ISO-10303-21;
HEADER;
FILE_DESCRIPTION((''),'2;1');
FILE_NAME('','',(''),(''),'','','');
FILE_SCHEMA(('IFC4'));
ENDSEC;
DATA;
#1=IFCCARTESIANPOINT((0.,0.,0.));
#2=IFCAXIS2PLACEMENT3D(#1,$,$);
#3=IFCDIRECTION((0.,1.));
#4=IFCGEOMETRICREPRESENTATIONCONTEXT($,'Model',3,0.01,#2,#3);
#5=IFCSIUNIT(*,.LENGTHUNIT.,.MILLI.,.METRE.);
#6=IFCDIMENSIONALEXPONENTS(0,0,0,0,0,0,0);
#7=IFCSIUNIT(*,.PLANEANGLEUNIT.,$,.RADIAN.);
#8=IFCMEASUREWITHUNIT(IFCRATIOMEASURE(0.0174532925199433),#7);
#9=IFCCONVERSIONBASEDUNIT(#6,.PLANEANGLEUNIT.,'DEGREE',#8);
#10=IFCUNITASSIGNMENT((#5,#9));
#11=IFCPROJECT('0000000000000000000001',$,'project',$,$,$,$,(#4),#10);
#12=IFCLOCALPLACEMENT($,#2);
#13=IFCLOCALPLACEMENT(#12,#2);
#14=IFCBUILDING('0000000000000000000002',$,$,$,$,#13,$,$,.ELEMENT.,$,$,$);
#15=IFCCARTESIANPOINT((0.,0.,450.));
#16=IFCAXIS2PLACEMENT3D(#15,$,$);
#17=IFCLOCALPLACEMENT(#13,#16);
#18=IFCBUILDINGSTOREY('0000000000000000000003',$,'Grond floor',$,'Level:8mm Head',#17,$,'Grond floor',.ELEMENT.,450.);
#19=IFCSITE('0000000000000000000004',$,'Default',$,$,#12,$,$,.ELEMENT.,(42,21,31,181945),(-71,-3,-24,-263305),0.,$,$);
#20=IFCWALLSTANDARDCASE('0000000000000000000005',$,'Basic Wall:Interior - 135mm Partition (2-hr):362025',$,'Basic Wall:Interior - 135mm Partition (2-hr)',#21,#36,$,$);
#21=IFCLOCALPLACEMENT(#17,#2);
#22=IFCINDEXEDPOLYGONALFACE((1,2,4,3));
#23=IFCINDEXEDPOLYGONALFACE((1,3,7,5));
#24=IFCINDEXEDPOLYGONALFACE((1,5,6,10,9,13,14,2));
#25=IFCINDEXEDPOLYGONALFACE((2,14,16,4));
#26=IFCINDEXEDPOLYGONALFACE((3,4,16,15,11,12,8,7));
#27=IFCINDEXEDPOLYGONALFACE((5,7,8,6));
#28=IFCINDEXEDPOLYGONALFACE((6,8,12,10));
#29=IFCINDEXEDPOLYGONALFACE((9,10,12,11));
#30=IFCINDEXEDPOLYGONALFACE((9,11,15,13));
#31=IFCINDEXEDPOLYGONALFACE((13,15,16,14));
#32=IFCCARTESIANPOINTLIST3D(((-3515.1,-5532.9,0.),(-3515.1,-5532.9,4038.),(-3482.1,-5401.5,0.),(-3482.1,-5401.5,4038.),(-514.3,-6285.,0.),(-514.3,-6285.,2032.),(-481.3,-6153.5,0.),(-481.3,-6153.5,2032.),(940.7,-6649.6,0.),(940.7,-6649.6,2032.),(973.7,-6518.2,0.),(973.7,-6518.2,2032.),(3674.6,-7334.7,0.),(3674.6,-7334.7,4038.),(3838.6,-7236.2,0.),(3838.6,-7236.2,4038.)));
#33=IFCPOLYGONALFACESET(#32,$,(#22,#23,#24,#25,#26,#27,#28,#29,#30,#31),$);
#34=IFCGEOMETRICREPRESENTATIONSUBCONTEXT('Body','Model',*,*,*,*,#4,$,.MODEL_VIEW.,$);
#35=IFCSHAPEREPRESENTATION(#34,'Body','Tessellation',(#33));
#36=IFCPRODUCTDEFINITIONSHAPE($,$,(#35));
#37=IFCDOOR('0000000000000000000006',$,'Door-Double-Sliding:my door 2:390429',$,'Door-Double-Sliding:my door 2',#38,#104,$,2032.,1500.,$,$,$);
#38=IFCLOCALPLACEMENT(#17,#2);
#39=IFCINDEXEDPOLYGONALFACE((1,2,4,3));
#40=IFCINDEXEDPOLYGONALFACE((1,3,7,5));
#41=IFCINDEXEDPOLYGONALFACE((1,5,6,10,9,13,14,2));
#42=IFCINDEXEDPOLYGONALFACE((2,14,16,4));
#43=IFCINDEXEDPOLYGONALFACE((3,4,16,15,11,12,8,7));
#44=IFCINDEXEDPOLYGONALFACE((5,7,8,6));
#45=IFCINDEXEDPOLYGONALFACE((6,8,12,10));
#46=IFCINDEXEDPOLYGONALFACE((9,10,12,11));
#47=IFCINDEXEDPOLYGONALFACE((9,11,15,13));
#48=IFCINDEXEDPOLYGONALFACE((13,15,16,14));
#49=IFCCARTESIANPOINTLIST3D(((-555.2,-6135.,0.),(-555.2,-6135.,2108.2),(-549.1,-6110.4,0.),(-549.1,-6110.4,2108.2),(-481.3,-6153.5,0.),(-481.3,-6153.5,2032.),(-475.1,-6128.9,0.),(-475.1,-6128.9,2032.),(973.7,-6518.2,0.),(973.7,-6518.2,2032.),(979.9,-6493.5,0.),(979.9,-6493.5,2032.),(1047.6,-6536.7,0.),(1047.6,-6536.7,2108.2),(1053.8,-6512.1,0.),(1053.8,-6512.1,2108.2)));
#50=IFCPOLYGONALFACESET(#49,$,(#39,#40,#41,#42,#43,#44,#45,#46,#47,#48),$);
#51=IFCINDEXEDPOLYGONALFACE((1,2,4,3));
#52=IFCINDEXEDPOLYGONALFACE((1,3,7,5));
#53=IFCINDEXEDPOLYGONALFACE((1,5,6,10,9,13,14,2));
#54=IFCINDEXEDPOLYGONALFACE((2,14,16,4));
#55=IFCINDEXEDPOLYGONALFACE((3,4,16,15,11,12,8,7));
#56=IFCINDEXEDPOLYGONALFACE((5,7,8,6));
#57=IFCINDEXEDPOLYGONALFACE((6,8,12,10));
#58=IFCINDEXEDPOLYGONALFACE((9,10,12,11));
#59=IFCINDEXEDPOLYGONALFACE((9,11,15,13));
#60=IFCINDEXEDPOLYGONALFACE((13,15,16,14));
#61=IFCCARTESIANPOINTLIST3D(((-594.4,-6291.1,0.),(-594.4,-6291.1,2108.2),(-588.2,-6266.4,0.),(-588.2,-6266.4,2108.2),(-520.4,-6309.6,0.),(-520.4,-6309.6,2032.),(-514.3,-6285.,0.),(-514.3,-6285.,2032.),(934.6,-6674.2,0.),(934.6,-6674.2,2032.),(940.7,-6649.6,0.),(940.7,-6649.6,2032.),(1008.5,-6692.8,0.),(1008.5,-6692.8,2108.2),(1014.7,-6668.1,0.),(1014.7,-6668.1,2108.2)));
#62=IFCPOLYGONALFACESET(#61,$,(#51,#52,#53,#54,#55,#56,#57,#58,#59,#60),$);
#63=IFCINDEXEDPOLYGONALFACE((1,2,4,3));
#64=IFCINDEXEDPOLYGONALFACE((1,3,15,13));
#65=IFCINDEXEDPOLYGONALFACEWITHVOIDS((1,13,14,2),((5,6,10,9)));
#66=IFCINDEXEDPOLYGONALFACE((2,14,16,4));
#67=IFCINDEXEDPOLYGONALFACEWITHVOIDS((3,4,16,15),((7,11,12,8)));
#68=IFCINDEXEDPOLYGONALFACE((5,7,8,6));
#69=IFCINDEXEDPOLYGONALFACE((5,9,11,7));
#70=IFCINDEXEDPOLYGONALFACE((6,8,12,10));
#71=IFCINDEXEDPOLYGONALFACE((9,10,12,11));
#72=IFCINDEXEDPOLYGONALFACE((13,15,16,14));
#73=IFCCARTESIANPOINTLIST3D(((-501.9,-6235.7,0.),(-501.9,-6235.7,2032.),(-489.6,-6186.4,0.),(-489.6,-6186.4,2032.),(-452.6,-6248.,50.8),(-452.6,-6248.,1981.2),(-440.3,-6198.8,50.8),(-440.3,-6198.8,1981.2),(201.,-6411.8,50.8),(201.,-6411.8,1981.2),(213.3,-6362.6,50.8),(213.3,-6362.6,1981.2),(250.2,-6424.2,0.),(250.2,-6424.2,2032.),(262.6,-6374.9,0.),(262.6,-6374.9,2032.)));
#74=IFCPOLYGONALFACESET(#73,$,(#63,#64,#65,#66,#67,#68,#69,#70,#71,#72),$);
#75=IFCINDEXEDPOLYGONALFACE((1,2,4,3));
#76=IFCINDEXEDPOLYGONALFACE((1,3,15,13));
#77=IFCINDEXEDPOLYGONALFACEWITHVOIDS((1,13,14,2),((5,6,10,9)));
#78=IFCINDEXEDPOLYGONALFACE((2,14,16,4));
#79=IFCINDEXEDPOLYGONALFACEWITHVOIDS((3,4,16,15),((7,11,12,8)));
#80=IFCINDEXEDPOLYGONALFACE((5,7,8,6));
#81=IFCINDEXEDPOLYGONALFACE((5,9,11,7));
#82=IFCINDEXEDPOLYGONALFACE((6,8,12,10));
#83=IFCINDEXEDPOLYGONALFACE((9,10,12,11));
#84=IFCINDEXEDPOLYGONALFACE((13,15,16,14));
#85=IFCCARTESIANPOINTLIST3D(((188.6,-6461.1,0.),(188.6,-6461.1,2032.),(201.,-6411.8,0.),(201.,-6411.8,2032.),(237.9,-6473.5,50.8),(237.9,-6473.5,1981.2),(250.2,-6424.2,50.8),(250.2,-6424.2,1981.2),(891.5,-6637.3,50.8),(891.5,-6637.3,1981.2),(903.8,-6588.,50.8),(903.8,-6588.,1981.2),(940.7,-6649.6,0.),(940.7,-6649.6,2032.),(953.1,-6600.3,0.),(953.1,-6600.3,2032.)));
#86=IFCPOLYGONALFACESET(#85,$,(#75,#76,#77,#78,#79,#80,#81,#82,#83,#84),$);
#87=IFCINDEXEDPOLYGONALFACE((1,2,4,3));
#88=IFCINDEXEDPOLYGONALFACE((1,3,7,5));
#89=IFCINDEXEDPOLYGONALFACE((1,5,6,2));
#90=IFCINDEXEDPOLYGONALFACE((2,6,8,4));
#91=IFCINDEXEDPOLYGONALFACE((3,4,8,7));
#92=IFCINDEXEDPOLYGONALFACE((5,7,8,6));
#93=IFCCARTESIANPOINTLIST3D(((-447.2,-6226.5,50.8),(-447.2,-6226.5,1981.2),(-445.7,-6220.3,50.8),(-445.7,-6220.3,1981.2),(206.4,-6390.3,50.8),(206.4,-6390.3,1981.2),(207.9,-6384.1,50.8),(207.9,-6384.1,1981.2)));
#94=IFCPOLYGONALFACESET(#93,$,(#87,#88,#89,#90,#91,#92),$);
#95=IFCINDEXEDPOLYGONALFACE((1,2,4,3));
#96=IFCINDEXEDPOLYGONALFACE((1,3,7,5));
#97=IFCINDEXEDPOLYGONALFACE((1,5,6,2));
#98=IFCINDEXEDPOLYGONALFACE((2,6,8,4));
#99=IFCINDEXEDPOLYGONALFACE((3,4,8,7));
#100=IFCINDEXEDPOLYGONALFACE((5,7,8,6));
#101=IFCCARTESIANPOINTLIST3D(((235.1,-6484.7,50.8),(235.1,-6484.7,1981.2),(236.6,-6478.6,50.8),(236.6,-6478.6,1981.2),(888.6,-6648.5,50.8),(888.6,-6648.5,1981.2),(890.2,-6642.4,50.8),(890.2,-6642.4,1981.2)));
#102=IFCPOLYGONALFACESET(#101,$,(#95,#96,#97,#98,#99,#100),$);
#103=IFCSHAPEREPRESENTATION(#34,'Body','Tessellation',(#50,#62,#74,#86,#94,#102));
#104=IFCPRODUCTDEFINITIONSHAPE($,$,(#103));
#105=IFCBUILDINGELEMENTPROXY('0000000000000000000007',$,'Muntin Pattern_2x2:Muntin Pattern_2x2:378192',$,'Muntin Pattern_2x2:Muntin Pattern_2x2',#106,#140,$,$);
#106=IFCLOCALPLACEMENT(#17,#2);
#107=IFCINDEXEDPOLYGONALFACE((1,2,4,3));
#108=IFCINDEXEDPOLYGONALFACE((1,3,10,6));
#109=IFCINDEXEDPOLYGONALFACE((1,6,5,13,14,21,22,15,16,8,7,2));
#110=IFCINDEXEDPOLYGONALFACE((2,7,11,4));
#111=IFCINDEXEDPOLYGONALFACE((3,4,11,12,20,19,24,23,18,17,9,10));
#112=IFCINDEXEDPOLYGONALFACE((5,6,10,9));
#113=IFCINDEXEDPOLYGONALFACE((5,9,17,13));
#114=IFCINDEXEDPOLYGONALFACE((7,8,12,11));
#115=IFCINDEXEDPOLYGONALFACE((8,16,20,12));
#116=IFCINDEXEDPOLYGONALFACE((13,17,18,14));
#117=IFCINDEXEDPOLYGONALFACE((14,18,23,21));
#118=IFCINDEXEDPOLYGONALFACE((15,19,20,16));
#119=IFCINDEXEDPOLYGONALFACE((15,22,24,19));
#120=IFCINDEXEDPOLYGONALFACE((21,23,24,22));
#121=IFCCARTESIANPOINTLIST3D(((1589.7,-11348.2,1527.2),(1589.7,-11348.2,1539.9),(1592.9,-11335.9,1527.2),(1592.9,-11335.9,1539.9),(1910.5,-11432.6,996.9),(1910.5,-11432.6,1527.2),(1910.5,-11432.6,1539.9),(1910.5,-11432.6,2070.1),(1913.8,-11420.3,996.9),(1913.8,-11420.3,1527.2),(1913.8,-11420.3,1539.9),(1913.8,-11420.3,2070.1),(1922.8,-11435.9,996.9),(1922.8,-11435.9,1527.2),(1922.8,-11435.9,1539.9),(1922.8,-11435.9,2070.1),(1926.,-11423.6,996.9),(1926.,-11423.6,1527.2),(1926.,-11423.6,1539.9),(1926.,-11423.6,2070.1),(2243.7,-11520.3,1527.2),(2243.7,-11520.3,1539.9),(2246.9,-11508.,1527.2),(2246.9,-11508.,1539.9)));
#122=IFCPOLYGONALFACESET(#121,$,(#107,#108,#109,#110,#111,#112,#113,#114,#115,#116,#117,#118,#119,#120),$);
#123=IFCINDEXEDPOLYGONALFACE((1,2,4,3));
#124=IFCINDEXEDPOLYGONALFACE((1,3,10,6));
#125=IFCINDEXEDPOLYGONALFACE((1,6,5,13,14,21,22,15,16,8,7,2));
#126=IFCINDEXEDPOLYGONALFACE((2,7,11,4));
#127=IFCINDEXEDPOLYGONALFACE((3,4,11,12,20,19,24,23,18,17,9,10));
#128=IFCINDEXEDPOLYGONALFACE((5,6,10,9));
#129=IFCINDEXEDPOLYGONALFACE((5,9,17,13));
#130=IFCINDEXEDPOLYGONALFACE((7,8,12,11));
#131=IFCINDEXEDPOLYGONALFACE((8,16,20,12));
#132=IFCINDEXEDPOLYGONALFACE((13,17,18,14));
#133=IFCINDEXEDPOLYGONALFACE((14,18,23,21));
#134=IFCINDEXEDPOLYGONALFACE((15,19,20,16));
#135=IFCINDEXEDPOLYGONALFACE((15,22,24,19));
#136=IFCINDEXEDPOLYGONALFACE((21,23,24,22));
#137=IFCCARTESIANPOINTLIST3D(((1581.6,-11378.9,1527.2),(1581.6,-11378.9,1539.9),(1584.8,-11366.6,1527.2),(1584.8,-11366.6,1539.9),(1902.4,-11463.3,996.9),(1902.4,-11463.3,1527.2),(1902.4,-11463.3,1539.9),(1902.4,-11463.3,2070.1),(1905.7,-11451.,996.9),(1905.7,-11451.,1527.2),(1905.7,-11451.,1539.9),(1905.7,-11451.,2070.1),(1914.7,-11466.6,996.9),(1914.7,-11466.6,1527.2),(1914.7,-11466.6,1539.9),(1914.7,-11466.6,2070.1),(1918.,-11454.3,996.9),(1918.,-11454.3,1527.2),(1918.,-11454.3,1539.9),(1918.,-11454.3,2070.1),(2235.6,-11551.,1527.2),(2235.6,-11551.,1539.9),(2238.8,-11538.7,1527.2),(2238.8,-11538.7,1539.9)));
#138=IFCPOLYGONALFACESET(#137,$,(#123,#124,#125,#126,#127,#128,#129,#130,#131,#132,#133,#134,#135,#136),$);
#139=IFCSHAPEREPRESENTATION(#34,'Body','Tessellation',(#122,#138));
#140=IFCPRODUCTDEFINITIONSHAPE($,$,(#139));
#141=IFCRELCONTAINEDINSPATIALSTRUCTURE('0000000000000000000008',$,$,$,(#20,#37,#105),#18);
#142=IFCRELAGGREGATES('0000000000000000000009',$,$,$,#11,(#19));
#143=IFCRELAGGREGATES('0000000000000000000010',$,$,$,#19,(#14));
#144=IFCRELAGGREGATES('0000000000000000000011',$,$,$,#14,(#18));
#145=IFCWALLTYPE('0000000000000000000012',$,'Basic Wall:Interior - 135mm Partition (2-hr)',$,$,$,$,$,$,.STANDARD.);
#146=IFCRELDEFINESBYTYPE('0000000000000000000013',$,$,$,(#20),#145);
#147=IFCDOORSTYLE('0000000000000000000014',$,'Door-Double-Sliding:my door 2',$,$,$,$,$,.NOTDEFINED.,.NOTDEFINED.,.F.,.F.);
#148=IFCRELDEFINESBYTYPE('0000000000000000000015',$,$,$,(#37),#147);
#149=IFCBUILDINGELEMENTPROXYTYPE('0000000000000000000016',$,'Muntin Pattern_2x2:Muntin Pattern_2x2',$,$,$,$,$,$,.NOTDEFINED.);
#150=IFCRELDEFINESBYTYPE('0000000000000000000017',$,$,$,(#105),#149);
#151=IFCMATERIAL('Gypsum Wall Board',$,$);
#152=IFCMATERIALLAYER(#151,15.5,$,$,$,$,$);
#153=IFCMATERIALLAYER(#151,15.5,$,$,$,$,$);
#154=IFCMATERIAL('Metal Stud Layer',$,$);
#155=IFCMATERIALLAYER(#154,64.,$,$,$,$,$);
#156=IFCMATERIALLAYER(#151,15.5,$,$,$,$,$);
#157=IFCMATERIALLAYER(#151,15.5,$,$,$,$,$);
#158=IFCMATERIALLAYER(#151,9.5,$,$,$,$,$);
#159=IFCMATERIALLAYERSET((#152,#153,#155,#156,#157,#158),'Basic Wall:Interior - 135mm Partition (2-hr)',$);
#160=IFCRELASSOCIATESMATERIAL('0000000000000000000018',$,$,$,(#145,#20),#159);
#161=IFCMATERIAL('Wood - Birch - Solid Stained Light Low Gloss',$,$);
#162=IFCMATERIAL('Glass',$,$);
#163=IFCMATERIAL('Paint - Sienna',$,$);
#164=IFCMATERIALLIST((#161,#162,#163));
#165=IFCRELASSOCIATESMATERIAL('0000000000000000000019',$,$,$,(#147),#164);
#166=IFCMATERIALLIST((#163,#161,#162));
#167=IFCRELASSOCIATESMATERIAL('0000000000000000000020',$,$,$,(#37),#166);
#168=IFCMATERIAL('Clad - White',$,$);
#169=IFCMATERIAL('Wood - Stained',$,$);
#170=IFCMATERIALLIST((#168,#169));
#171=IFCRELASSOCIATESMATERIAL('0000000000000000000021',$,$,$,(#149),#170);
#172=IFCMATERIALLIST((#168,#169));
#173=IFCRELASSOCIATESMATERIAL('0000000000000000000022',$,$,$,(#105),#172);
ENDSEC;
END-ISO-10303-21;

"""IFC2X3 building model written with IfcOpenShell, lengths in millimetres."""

from ifc_helpers import new_model, entity, si_unit, converted_unit, direction, frame, frame_2d, origin, origin_2d_with_axis, place, context, subcontext, project, spatial, polyline, rectangle, outline, extrude, source, transform, mapped, material, material_list, layer, layer_set, layer_usage, type_object, type_shapes, element, fill, save


model = new_model("IFC2X3")

# Units and contexts
model_context = context("Model", 3, precision=0.01, world=origin(), true_north=direction((0.0, 1.0)))
body_context = subcontext(model_context, "Body", "Model", "MODEL_VIEW")
ifc_project = project(units=[si_unit("LENGTHUNIT", "METRE", prefix="MILLI"), converted_unit("PLANEANGLEUNIT", "DEGREE", entity("IfcRatioMeasure", 0.0174532925199433), si_unit("PLANEANGLEUNIT", "RADIAN"), dimensions=[0, 0, 0, 0, 0, 0, 0])], contexts=[model_context])

# Site, building, storey
site_placement = place(None, origin())
site = spatial("IfcSite", under=ifc_project, at=site_placement, Name="Default", CompositionType="ELEMENT", RefLatitude=(42, 21, 31, 181945), RefLongitude=(-71, -3, -24, -263305), RefElevation=0.0)
building_placement = place(site_placement, origin())
building = spatial("IfcBuilding", under=site, at=building_placement, CompositionType="ELEMENT")
storey_placement = place(building_placement, frame((0.0, 0.0, 450.0)))
storey = spatial("IfcBuildingStorey", under=building, at=storey_placement, Name="Grond floor", ObjectType="Level:8mm Head", LongName="Grond floor", CompositionType="ELEMENT", Elevation=450.0)

# Shared definitions
ifc_material_1 = material(Name="Glass")

# Shared definitions
ifc_material_2 = material(Name="Gypsum Wall Board")

# Wall, openings, door
ifc_layer_1 = layer(ifc_material_2, 15.5)
ifc_layer_2 = layer(ifc_material_2, 15.5)
ifc_material_3 = material(Name="Metal Stud Layer")
ifc_layer_3 = layer(ifc_material_3, 64.0)
ifc_layer_4 = layer(ifc_material_2, 15.5)
ifc_layer_5 = layer(ifc_material_2, 15.5)
ifc_layer_6 = layer(ifc_material_2, 9.5)
ifc_layer_set_1 = layer_set([ifc_layer_1, ifc_layer_2, ifc_layer_3, ifc_layer_4, ifc_layer_5, ifc_layer_6], Name="Basic Wall:Interior - 135mm Partition (2-hr)")
ifc_layer_usage_1 = layer_usage(ifc_layer_set_1, "AXIS2", "NEGATIVE", 67.8)
wall_type_1 = type_object("IfcWallType", Name="Basic Wall:Interior - 135mm Partition (2-hr)", PredefinedType="STANDARD", material=ifc_layer_set_1)
wall_1_placement = place(storey_placement, frame((3822.2, -7301.9, 0.0), z_axis=(0.0, 0.0, 1.0), x_axis=(-0.970003, 0.243092, 0.0)))
wall_1 = element("IfcWallStandardCase", 1, at=wall_1_placement, inside=storey, type_object=wall_type_1, material=ifc_layer_usage_1, Name="Basic Wall:Interior - 135mm Partition (2-hr):362025", ObjectType="Basic Wall:Interior - 135mm Partition (2-hr)", context=body_context, shape_type="SweptSolid", body=[
    extrude(outline(polyline([(0.0, -67.8), (7547.1, -67.8), (7547.1, 67.7), (135.2, 67.7), (17.7, -50.0), (0.0, -67.8)])), origin(), (0.0, 0.0, 1.0), 4038.0),
])
opening_1_placement = place(wall_1_placement, origin())
element("IfcOpeningElement", 2, at=opening_1_placement, cuts=wall_1, ObjectType="Opening", context=body_context, shape_type="SweptSolid", body=[
    extrude(rectangle(XDim=2134.0, YDim=135.5, at=frame_2d((0.0, 0.0), x_axis=(0.0, 1.0))), frame((4614.9, 174.8, 1067.0), z_axis=(0.0, 1.0, 0.0), x_axis=(1.0, 0.0, 0.0)), (0.0, 0.0, 1.0), 813.0),
])
opening_2_placement = place(wall_1_placement, origin())
element("IfcOpeningElement", 3, at=opening_2_placement, cuts=wall_1, ObjectType="Opening", context=body_context, shape_type="SweptSolid", body=[
    extrude(rectangle(XDim=2134.0, YDim=135.5, at=frame_2d((0.0, 0.0), x_axis=(0.0, 1.0))), frame((2773.7, 196.6, 1067.0), z_axis=(0.0, 1.0, 0.0), x_axis=(1.0, 0.0, 0.0)), (0.0, 0.0, 1.0), 813.0),
])
opening_3_placement = place(wall_1_placement, origin())
element("IfcOpeningElement", 4, at=opening_3_placement, cuts=wall_1, ObjectType="Opening", context=body_context, shape_type="SweptSolid", body=[
    extrude(rectangle(XDim=2134.0, YDim=915.0, at=frame_2d((0.0, 0.0), x_axis=(0.0, 1.0))), frame((7996.1, -510.0, 1067.0), z_axis=(0.514003, 0.857788, 0.0), x_axis=(-0.857788, 0.514003, 0.0)), (0.0, 0.0, 1.0), 264.0),
])
opening_4_placement = place(wall_1_placement, frame((2953.5, -67.7, 0.0)))
opening_4 = element("IfcOpeningElement", 5, at=opening_4_placement, cuts=wall_1, ObjectType="Opening", context=body_context, shape_type="SweptSolid", body=[
    extrude(rectangle(XDim=2032.0, YDim=1500.0, at=frame_2d((1016.0, 750.0), x_axis=(-1.0, 0.0))), frame((0.0, 0.0, 0.0), z_axis=(0.0, 1.0, 0.0), x_axis=(0.0, 0.0, 1.0)), (0.0, 0.0, 1.0), 135.5),
])
ifc_material_4 = material(Name="Paint - Sienna")
ifc_material_5 = material(Name="Wood - Birch - Solid Stained Light Low Gloss")
ifc_material_list_1 = material_list([ifc_material_4, ifc_material_5, ifc_material_1])
ifc_material_list_2 = material_list([ifc_material_5, ifc_material_1, ifc_material_4])
door_style = type_object("IfcDoorStyle", Name="Door-Double-Sliding:my door 2", ConstructionType="NOTDEFINED", OperationType="NOTDEFINED", ParameterTakesPrecedence=False, Sizeable=False, material=ifc_material_list_2)
shared_shape_1 = source(origin(), body_context, "Body", "SweptSolid", [
    extrude(outline(polyline([(-1035.0, -826.2), (1073.2, -826.2), (1073.2, 826.2), (-1035.0, 826.2), (-1035.0, 750.0), (996.9, 750.0), (996.9, -750.0), (-1035.0, -750.0), (-1035.0, -826.2)])), frame((750.0, -25.4, 1035.0), z_axis=(0.0, 1.0, 0.0), x_axis=(0.0, 0.0, 1.0)), (0.0, 0.0, 1.0), 25.4),
    extrude(outline(polyline([(-826.2, -1035.0), (-750.0, -1035.0), (-750.0, 997.0), (750.0, 997.0), (750.0, -1035.0), (826.2, -1035.0), (826.2, 1073.2), (-826.2, 1073.2), (-826.2, -1035.0)])), frame((750.0, 135.5, 1035.0), z_axis=(0.0, 1.0, 0.0), x_axis=(-1.0, 0.0, 0.0)), (0.0, 0.0, 1.0), 25.4),
    extrude(outline(polyline([(-387.7, -1016.0), (387.7, -1016.0), (387.7, 1016.0), (-387.7, 1016.0), (-387.7, -1016.0)]), holes=[polyline([(-336.9, -965.2), (-336.9, 965.2), (336.9, 965.2), (336.9, -965.2), (-336.9, -965.2)])]), frame((1112.3, 33.9, 1016.0), z_axis=(0.0, 1.0, 0.0), x_axis=(1.0, 0.0, 0.0)), (0.0, 0.0, 1.0), 50.8),
    extrude(outline(polyline([(-1016.0, -387.7), (1016.0, -387.7), (1016.0, 387.7), (-1016.0, 387.7), (-1016.0, -387.7)]), holes=[polyline([(-965.2, -336.9), (-965.2, 336.9), (965.2, 336.9), (965.2, -336.9), (-965.2, -336.9)])]), frame((387.7, 84.7, 1016.0), z_axis=(0.0, 1.0, 0.0), x_axis=(0.0, 0.0, -1.0)), (0.0, 0.0, 1.0), 50.8),
    extrude(rectangle(XDim=6.3, YDim=673.8, at=frame_2d((0.0, 0.0), x_axis=(1.0, 0.0))), frame((1112.3, 59.3, 50.8), z_axis=(0.0, 0.0, 1.0), x_axis=(0.0, -1.0, 0.0)), (0.0, 0.0, 1.0), 1930.4),
    extrude(rectangle(XDim=6.4, YDim=673.8, at=origin_2d_with_axis()), frame((387.7, 144.0, 50.8), z_axis=(0.0, 0.0, 1.0), x_axis=(0.0, 1.0, 0.0)), (0.0, 0.0, 1.0), 1930.4),
])
type_shapes(door_style, [shared_shape_1])
door_placement = place(opening_4_placement, origin())
door = element("IfcDoor", 6, at=door_placement, inside=storey, type_object=door_style, material=ifc_material_list_1, Name="Door-Double-Sliding:my door 2:390429", ObjectType="Door-Double-Sliding:my door 2", OverallHeight=2032.0, OverallWidth=1500.0, context=body_context, shape_type="MappedRepresentation", body=[
    mapped(shared_shape_1, transform((0.0, 0.0, 0.0), scale=1.0)),
])
fill(opening_4, door)

# Building element proxy
ifc_material_6 = material(Name="Clad - White")
ifc_material_7 = material(Name="Wood - Stained")
ifc_material_list_3 = material_list([ifc_material_6, ifc_material_7])
ifc_material_list_4 = material_list([ifc_material_6, ifc_material_7])
building_element_proxy_type_1 = type_object("IfcBuildingElementProxyType", Name="Muntin Pattern_2x2:Muntin Pattern_2x2", PredefinedType="NOTDEFINED", material=ifc_material_list_4)
shared_shape_2 = source(origin(), body_context, "Body", "SweptSolid", [
    extrude(outline(polyline([(6.4, -6.4), (536.6, -6.4), (536.6, 6.3), (6.4, 6.3), (6.4, 338.1), (-6.3, 338.1), (-6.3, 6.3), (-536.6, 6.3), (-536.6, -6.4), (-6.3, -6.4), (-6.3, -338.1), (6.4, -338.1), (6.4, -6.4)])), frame((0.0, 9.5, 536.6), z_axis=(0.0, 1.0, 0.0), x_axis=(0.0, 0.0, 1.0)), (0.0, 0.0, 1.0), 12.7),
    extrude(outline(polyline([(6.4, -6.4), (536.6, -6.4), (536.6, 6.3), (6.4, 6.3), (6.4, 338.1), (-6.3, 338.1), (-6.3, 6.3), (-536.6, 6.3), (-536.6, -6.4), (-6.3, -6.4), (-6.3, -338.1), (6.4, -338.1), (6.4, -6.4)])), frame((0.0, -22.2, 536.6), z_axis=(0.0, 1.0, 0.0), x_axis=(0.0, 0.0, 1.0)), (0.0, 0.0, 1.0), 12.7),
])
type_shapes(building_element_proxy_type_1, [shared_shape_2])
proxy_1_placement = place(storey_placement, frame((1914.2, -11443.4, 996.9), z_axis=(0.0, 0.0, 1.0), x_axis=(0.967067, -0.25452, 0.0)))
element("IfcBuildingElementProxy", 7, at=proxy_1_placement, inside=storey, type_object=building_element_proxy_type_1, material=ifc_material_list_3, Name="Muntin Pattern_2x2:Muntin Pattern_2x2:378192", ObjectType="Muntin Pattern_2x2:Muntin Pattern_2x2", context=body_context, shape_type="MappedRepresentation", body=[
    mapped(shared_shape_2, transform((0.0, 0.0, 0.0), scale=1.0)),
])

save(model, "model.ifc")
